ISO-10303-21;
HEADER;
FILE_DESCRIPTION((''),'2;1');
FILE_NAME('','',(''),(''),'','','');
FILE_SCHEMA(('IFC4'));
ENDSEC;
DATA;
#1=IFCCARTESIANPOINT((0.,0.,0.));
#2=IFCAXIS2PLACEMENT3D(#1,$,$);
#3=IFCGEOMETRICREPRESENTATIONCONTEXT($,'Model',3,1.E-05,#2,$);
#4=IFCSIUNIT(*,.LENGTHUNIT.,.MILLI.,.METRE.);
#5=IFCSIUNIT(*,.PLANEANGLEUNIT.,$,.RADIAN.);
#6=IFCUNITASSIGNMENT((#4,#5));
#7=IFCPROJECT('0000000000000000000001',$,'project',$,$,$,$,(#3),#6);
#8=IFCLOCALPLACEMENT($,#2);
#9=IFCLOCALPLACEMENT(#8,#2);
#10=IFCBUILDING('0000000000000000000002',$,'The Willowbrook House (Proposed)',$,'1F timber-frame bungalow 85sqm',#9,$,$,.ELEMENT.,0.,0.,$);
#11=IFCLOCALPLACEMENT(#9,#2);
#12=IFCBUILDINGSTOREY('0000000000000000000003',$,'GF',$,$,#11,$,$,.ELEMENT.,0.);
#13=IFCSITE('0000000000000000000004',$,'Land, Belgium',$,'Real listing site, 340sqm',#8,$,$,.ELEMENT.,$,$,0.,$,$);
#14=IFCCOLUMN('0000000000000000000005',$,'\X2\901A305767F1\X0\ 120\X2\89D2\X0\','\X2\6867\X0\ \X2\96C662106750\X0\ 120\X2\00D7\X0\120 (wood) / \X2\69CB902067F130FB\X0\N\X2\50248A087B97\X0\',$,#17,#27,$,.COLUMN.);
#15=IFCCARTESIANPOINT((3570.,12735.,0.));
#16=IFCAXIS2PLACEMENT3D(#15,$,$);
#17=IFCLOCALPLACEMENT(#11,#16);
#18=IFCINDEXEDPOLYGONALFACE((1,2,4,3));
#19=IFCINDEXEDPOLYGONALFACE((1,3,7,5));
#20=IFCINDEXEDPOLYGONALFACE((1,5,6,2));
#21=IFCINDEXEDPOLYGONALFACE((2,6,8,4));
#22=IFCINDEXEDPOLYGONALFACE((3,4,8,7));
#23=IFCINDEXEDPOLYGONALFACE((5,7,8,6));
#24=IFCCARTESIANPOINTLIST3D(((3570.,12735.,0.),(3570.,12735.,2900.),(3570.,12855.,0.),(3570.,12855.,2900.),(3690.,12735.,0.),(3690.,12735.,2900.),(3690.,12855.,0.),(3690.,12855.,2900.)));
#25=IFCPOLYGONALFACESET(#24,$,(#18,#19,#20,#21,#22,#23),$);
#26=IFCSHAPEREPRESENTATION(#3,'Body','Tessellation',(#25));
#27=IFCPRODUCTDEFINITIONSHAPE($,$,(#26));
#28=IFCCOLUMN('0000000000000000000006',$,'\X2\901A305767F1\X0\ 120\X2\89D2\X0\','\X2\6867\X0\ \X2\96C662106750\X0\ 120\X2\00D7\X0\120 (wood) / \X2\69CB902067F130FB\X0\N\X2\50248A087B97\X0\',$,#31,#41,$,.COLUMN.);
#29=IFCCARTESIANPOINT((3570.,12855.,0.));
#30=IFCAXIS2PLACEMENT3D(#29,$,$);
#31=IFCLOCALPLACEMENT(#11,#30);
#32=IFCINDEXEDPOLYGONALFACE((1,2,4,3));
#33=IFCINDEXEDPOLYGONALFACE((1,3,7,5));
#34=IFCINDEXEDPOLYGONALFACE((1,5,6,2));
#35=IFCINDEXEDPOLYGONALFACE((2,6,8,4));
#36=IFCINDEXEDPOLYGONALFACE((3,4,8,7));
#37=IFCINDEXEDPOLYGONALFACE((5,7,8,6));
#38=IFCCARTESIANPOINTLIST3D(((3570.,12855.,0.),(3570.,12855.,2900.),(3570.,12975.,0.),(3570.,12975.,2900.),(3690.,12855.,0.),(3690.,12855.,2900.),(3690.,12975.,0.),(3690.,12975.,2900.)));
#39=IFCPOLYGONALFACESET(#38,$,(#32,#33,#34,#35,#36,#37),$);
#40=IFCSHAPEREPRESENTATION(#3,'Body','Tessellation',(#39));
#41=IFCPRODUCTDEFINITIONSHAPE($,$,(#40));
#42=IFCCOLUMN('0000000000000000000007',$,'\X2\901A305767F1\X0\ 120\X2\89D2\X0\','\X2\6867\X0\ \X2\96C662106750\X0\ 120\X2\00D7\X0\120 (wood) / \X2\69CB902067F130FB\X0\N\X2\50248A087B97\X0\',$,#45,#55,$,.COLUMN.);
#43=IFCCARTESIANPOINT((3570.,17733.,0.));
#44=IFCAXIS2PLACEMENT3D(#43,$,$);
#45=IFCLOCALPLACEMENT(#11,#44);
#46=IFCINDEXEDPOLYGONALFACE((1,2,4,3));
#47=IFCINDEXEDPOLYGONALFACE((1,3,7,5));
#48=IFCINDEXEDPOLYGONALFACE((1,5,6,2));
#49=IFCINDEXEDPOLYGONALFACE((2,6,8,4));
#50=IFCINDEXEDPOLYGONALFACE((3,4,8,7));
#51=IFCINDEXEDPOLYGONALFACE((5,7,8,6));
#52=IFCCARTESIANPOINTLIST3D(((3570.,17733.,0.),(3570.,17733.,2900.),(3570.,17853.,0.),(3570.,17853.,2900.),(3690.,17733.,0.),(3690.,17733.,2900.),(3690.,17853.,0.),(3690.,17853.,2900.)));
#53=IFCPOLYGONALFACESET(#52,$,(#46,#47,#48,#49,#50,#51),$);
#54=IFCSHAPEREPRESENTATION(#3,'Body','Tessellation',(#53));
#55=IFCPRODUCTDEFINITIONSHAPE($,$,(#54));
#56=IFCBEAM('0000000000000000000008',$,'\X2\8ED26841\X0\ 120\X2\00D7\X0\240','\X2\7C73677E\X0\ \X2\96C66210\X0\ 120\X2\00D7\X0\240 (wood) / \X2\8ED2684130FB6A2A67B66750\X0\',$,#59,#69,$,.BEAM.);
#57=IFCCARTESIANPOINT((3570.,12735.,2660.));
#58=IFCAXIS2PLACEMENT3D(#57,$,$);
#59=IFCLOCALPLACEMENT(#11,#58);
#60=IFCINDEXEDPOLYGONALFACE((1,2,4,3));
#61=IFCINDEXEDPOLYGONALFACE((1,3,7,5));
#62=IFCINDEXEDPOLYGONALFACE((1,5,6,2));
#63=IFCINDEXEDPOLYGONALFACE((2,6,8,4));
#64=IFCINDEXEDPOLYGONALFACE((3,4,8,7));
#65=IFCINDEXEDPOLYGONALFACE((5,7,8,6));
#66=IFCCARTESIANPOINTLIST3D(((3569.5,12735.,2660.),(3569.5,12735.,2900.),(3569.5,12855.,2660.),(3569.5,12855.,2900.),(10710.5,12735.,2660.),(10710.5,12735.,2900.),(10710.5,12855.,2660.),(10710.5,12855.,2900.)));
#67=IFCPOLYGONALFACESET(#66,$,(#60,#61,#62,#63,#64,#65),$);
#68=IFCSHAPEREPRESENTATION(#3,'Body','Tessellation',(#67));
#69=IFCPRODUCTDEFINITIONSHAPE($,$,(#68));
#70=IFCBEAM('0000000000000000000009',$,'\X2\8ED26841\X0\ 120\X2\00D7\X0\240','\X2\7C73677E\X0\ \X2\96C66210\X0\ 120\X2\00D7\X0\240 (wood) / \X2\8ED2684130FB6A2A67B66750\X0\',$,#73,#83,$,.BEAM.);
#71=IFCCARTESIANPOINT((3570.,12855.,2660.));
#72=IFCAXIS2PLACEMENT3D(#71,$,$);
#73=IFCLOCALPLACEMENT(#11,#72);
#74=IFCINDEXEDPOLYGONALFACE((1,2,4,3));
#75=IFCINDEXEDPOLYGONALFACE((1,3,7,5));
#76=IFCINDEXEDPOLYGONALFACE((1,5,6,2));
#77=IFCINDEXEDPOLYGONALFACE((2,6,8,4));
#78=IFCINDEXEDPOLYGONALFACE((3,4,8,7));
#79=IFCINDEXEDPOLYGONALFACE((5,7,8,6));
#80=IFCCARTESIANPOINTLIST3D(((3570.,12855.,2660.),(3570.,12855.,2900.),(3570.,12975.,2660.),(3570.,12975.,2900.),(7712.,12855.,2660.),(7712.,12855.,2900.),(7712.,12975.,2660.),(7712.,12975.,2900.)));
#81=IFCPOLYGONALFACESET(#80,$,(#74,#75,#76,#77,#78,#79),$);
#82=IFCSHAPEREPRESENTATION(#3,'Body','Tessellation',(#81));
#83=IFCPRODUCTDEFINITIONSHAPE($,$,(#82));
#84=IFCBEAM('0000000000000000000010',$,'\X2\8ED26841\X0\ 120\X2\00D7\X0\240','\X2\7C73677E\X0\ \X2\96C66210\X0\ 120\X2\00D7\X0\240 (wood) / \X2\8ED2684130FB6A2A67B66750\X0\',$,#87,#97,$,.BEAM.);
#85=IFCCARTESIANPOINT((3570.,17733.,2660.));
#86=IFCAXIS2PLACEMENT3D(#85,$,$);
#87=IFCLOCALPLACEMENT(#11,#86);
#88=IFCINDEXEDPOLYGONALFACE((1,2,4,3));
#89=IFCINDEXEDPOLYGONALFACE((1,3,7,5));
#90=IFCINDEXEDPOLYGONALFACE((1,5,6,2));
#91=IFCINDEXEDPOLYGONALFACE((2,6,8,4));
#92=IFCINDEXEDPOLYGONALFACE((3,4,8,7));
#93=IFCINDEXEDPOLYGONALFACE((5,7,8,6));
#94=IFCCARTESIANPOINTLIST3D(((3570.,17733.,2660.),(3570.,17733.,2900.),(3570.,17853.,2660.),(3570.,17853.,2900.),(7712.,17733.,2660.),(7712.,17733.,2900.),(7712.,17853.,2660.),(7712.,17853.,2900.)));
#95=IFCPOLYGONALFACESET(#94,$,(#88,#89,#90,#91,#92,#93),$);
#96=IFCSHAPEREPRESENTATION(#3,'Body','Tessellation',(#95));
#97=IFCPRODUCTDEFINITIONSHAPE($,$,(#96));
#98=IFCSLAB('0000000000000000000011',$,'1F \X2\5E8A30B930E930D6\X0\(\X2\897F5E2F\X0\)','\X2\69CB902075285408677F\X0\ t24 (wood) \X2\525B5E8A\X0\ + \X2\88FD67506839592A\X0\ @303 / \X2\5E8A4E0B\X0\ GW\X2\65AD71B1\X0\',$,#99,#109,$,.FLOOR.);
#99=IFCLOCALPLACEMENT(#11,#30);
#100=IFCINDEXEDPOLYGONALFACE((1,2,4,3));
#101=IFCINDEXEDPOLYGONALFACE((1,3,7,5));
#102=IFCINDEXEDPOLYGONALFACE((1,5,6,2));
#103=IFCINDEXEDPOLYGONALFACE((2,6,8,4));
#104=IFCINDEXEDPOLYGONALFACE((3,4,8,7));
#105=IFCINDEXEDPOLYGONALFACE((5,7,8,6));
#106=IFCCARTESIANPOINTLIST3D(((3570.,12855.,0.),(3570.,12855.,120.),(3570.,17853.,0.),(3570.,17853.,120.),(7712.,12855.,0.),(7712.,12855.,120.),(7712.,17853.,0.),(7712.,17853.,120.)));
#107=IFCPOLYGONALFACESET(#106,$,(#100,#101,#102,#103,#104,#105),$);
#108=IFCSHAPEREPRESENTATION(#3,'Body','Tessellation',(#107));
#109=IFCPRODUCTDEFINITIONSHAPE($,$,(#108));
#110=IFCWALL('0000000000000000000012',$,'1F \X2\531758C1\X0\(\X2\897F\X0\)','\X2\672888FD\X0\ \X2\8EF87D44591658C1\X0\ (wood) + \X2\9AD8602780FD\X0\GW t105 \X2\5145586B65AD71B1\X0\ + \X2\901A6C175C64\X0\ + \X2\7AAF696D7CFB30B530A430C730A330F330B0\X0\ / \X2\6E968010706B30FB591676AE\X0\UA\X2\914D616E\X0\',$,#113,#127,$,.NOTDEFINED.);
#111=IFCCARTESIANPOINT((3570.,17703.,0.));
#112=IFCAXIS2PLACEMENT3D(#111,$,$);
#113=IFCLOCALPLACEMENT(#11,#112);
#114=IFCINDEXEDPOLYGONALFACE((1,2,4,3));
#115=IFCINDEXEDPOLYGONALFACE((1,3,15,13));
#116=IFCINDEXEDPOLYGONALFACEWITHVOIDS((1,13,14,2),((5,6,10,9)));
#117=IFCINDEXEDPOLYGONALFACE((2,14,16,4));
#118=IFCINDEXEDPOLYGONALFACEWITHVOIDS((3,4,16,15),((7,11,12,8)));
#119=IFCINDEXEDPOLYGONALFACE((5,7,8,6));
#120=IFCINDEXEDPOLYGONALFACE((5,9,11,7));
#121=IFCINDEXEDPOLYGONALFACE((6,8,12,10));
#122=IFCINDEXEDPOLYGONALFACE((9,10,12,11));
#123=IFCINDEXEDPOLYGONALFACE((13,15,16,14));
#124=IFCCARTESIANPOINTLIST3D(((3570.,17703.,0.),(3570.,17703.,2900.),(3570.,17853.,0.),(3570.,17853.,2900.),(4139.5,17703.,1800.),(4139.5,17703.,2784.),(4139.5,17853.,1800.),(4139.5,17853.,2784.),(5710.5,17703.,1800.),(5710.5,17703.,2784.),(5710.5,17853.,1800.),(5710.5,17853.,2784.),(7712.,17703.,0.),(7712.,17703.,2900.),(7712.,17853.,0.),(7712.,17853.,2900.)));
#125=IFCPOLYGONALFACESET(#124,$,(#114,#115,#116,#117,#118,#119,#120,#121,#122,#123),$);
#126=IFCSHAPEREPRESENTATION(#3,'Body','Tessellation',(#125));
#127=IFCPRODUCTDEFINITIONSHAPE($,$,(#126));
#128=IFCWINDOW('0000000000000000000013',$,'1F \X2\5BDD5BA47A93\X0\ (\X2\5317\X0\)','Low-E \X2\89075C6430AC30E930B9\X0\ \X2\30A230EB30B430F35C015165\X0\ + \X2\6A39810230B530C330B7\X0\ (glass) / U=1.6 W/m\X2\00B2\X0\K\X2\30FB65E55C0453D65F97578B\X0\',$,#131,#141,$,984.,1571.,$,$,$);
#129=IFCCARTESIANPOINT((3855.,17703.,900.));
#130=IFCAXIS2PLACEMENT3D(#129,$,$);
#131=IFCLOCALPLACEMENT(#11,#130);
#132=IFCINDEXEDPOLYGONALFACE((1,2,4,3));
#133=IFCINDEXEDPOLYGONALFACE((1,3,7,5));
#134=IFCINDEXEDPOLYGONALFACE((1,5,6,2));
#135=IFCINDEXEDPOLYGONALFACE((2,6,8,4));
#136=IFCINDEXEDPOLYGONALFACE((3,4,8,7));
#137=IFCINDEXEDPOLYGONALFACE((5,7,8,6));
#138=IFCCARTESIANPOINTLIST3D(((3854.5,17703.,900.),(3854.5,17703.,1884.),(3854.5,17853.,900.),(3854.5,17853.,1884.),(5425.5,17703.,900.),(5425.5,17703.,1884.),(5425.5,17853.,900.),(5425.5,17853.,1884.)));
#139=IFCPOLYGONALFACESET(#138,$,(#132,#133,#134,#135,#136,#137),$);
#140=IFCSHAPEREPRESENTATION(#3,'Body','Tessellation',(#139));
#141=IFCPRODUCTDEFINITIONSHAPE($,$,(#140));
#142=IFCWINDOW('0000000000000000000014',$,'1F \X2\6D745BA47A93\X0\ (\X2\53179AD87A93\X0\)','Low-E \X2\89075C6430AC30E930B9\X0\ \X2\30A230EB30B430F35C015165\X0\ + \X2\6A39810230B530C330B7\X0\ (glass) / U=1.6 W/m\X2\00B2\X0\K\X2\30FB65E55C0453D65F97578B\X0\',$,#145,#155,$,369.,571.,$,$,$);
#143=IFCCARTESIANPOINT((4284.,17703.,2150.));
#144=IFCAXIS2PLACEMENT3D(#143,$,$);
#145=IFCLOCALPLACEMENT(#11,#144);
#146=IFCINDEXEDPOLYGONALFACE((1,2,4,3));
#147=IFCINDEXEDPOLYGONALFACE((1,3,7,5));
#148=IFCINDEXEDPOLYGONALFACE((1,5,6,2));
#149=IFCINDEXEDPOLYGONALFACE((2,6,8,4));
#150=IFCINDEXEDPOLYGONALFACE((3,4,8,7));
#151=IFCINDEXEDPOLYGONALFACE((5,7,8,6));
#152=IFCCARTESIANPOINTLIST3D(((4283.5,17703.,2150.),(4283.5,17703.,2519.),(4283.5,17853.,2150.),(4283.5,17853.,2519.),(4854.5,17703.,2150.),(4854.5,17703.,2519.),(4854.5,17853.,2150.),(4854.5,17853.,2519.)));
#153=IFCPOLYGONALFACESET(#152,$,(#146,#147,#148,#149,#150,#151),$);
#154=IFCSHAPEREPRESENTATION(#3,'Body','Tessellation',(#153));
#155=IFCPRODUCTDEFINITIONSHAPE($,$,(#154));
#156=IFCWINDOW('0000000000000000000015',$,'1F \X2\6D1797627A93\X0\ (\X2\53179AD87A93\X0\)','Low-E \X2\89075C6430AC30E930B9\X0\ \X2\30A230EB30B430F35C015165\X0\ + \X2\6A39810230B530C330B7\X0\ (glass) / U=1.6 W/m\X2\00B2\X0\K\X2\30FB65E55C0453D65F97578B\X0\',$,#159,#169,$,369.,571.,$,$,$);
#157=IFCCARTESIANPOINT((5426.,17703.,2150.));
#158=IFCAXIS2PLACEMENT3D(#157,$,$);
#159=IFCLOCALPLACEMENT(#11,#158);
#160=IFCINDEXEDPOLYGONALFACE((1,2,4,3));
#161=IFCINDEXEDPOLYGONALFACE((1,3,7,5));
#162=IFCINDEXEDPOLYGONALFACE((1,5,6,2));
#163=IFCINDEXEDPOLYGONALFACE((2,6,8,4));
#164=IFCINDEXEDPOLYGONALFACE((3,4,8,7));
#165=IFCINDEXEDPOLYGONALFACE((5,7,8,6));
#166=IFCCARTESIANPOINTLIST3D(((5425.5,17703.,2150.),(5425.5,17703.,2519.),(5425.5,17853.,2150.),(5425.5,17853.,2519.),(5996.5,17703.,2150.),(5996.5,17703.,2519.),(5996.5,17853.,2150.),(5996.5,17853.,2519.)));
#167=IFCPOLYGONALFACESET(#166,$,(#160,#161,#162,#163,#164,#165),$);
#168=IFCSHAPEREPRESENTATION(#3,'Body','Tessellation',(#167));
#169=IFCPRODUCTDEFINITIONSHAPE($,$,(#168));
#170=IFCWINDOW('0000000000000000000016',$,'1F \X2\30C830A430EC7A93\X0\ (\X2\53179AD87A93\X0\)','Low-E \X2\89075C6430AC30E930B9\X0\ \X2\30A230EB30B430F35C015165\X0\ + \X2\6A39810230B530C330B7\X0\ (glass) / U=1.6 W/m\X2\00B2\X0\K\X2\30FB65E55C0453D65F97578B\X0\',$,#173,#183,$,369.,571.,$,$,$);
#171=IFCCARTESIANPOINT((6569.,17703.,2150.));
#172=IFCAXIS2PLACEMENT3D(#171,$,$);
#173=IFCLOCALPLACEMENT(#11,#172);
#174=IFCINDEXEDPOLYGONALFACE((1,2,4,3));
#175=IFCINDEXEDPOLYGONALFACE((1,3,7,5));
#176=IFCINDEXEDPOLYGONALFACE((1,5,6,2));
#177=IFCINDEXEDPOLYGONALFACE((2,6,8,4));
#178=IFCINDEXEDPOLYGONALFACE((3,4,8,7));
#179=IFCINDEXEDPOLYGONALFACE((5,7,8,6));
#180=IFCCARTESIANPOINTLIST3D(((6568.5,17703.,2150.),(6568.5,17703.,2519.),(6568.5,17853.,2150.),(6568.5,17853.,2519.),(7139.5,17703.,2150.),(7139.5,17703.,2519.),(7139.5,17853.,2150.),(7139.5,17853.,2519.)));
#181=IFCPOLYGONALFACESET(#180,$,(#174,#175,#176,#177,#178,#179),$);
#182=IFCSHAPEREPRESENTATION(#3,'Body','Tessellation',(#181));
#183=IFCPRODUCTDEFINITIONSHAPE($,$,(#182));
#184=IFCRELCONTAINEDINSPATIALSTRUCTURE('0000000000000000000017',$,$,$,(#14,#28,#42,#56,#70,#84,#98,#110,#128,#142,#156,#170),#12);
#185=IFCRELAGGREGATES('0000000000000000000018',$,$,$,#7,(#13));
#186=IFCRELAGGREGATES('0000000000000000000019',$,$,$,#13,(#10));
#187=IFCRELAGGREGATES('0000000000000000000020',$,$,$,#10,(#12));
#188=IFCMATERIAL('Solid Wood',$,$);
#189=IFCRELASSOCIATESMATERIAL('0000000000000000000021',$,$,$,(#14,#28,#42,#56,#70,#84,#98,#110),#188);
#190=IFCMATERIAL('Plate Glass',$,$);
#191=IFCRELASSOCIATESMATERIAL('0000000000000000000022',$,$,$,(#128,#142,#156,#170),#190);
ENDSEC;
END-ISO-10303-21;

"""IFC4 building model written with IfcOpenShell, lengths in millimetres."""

from ifc_helpers import new_model, si_unit, frame, frame_2d, origin, place, context, project, spatial, rectangle, extrude, material, element, fill, save


model = new_model("IFC4")

# Units and contexts
model_context = context("Model", 3, precision=1e-05, world=origin())
ifc_project = project(units=[si_unit("LENGTHUNIT", "METRE", prefix="MILLI"), si_unit("PLANEANGLEUNIT", "RADIAN")], contexts=[model_context])

# Site, building, storey
site_placement = place(None, origin())
site = spatial("IfcSite", under=ifc_project, at=site_placement, Name="Land, Belgium", ObjectType="Real listing site, 340sqm", CompositionType="ELEMENT", RefElevation=0.0)
building_placement = place(site_placement, origin())
building = spatial("IfcBuilding", under=site, at=building_placement, Name="The Willowbrook House (Proposed)", ObjectType="1F timber-frame bungalow 85sqm", CompositionType="ELEMENT", ElevationOfRefHeight=0.0, ElevationOfTerrain=0.0)
storey_placement = place(building_placement, origin())
storey = spatial("IfcBuildingStorey", under=building, at=storey_placement, Name="GF", CompositionType="ELEMENT", Elevation=0.0)

# Columns
ifc_material_1 = material(Name="Solid Wood")
column_1_placement = place(storey_placement, frame((3570.0, 12735.0, 0.0)))
element("IfcColumn", 1, at=column_1_placement, inside=storey, material=ifc_material_1, Name="通し柱 120角", Description="桧 集成材 120×120 (wood) / 構造柱・N値計算", PredefinedType="COLUMN", context=model_context, shape_type="SweptSolid", body=[
    extrude(rectangle(XDim=120.0, YDim=120.0, at=frame_2d((60.0, 60.0))), frame((3570.0, 12735.0, 0.0)), (0.0, 0.0, 1.0), 2900.0),
])
column_2_placement = place(storey_placement, frame((3570.0, 12855.0, 0.0)))
element("IfcColumn", 2, at=column_2_placement, inside=storey, material=ifc_material_1, Name="通し柱 120角", Description="桧 集成材 120×120 (wood) / 構造柱・N値計算", PredefinedType="COLUMN", context=model_context, shape_type="SweptSolid", body=[
    extrude(rectangle(XDim=120.0, YDim=120.0, at=frame_2d((60.0, 60.0))), frame((3570.0, 12855.0, 0.0)), (0.0, 0.0, 1.0), 2900.0),
])
column_3_placement = place(storey_placement, frame((3570.0, 17733.0, 0.0)))
element("IfcColumn", 3, at=column_3_placement, inside=storey, material=ifc_material_1, Name="通し柱 120角", Description="桧 集成材 120×120 (wood) / 構造柱・N値計算", PredefinedType="COLUMN", context=model_context, shape_type="SweptSolid", body=[
    extrude(rectangle(XDim=120.0, YDim=120.0, at=frame_2d((60.0, 60.0))), frame((3570.0, 17733.0, 0.0)), (0.0, 0.0, 1.0), 2900.0),
])

# Beams
beam_1_placement = place(storey_placement, frame((3570.0, 12735.0, 2660.0)))
element("IfcBeam", 4, at=beam_1_placement, inside=storey, material=ifc_material_1, Name="軒桁 120×240", Description="米松 集成 120×240 (wood) / 軒桁・横架材", PredefinedType="BEAM", context=model_context, shape_type="SweptSolid", body=[
    extrude(rectangle(XDim=7141.0, YDim=120.0, at=frame_2d((3570.0, 60.0))), frame((3570.0, 12735.0, 2660.0)), (0.0, 0.0, 1.0), 240.0),
])
beam_2_placement = place(storey_placement, frame((3570.0, 12855.0, 2660.0)))
element("IfcBeam", 5, at=beam_2_placement, inside=storey, material=ifc_material_1, Name="軒桁 120×240", Description="米松 集成 120×240 (wood) / 軒桁・横架材", PredefinedType="BEAM", context=model_context, shape_type="SweptSolid", body=[
    extrude(rectangle(XDim=4142.0, YDim=120.0, at=frame_2d((2071.0, 60.0))), frame((3570.0, 12855.0, 2660.0)), (0.0, 0.0, 1.0), 240.0),
])
beam_3_placement = place(storey_placement, frame((3570.0, 17733.0, 2660.0)))
element("IfcBeam", 6, at=beam_3_placement, inside=storey, material=ifc_material_1, Name="軒桁 120×240", Description="米松 集成 120×240 (wood) / 軒桁・横架材", PredefinedType="BEAM", context=model_context, shape_type="SweptSolid", body=[
    extrude(rectangle(XDim=4142.0, YDim=120.0, at=frame_2d((2071.0, 60.0))), frame((3570.0, 17733.0, 2660.0)), (0.0, 0.0, 1.0), 240.0),
])

# Slab
slab_placement = place(storey_placement, frame((3570.0, 12855.0, 0.0)))
element("IfcSlab", 7, at=slab_placement, inside=storey, material=ifc_material_1, Name="1F 床スラブ(西帯)", Description="構造用合板 t24 (wood) 剛床 + 製材根太 @303 / 床下 GW断熱", PredefinedType="FLOOR", context=model_context, shape_type="SweptSolid", body=[
    extrude(rectangle(XDim=4142.0, YDim=4998.0, at=frame_2d((2071.0, 2499.0))), frame((3570.0, 12855.0, 0.0)), (0.0, 0.0, 1.0), 120.0),
])

# Wall, openings, windows
wall_1_placement = place(storey_placement, frame((3570.0, 17703.0, 0.0)))
wall_1 = element("IfcWall", 8, at=wall_1_placement, inside=storey, material=ifc_material_1, Name="1F 北壁(西)", Description="木製 軸組外壁 (wood) + 高性能GW t105 充填断熱 + 通気層 + 窯業系サイディング / 準耐火・外皮UA配慮", PredefinedType="NOTDEFINED", context=model_context, shape_type="SweptSolid", body=[
    extrude(rectangle(XDim=4142.0, YDim=150.0, at=frame_2d((2071.0, 75.0))), frame((3570.0, 17703.0, 0.0)), (0.0, 0.0, 1.0), 2900.0),
])
opening_1_placement = place(storey_placement, frame((3855.0, 17703.0, 900.0)))
opening_1 = element("IfcOpeningElement", 9, at=opening_1_placement, cuts=wall_1, PredefinedType="NOTDEFINED", context=model_context, shape_type="SweptSolid", body=[
    extrude(rectangle(XDim=1571.0, YDim=150.0, at=frame_2d((785.0, 75.0))), frame((3855.0, 17703.0, 900.0)), (0.0, 0.0, 1.0), 984.0),
])
opening_2_placement = place(storey_placement, frame((4284.0, 17703.0, 2150.0)))
opening_2 = element("IfcOpeningElement", 10, at=opening_2_placement, cuts=wall_1, PredefinedType="NOTDEFINED", context=model_context, shape_type="SweptSolid", body=[
    extrude(rectangle(XDim=571.0, YDim=150.0, at=frame_2d((285.0, 75.0))), frame((4284.0, 17703.0, 2150.0)), (0.0, 0.0, 1.0), 369.0),
])
opening_3_placement = place(storey_placement, frame((5426.0, 17703.0, 2150.0)))
opening_3 = element("IfcOpeningElement", 11, at=opening_3_placement, cuts=wall_1, PredefinedType="NOTDEFINED", context=model_context, shape_type="SweptSolid", body=[
    extrude(rectangle(XDim=571.0, YDim=150.0, at=frame_2d((285.0, 75.0))), frame((5426.0, 17703.0, 2150.0)), (0.0, 0.0, 1.0), 369.0),
])
opening_4_placement = place(storey_placement, frame((6569.0, 17703.0, 2150.0)))
opening_4 = element("IfcOpeningElement", 12, at=opening_4_placement, cuts=wall_1, PredefinedType="NOTDEFINED", context=model_context, shape_type="SweptSolid", body=[
    extrude(rectangle(XDim=571.0, YDim=150.0, at=frame_2d((285.0, 75.0))), frame((6569.0, 17703.0, 2150.0)), (0.0, 0.0, 1.0), 369.0),
])
ifc_material_2 = material(Name="Plate Glass")
window_1_placement = place(storey_placement, frame((3855.0, 17703.0, 900.0)))
window_1 = element("IfcWindow", 13, at=window_1_placement, inside=storey, material=ifc_material_2, Name="1F 寝室窓 (北)", Description="Low-E 複層ガラス アルゴン封入 + 樹脂サッシ (glass) / U=1.6 W/m²K・日射取得型", OverallHeight=984.0, OverallWidth=1571.0, context=model_context, shape_type="SweptSolid", body=[
    extrude(rectangle(XDim=1571.0, YDim=150.0, at=frame_2d((785.0, 75.0))), frame((3855.0, 17703.0, 900.0)), (0.0, 0.0, 1.0), 984.0),
])
fill(opening_1, window_1)
window_2_placement = place(storey_placement, frame((4284.0, 17703.0, 2150.0)))
window_2 = element("IfcWindow", 14, at=window_2_placement, inside=storey, material=ifc_material_2, Name="1F 浴室窓 (北高窓)", Description="Low-E 複層ガラス アルゴン封入 + 樹脂サッシ (glass) / U=1.6 W/m²K・日射取得型", OverallHeight=369.0, OverallWidth=571.0, context=model_context, shape_type="SweptSolid", body=[
    extrude(rectangle(XDim=571.0, YDim=150.0, at=frame_2d((285.0, 75.0))), frame((4284.0, 17703.0, 2150.0)), (0.0, 0.0, 1.0), 369.0),
])
fill(opening_2, window_2)
window_3_placement = place(storey_placement, frame((5426.0, 17703.0, 2150.0)))
window_3 = element("IfcWindow", 15, at=window_3_placement, inside=storey, material=ifc_material_2, Name="1F 洗面窓 (北高窓)", Description="Low-E 複層ガラス アルゴン封入 + 樹脂サッシ (glass) / U=1.6 W/m²K・日射取得型", OverallHeight=369.0, OverallWidth=571.0, context=model_context, shape_type="SweptSolid", body=[
    extrude(rectangle(XDim=571.0, YDim=150.0, at=frame_2d((285.0, 75.0))), frame((5426.0, 17703.0, 2150.0)), (0.0, 0.0, 1.0), 369.0),
])
fill(opening_3, window_3)
window_4_placement = place(storey_placement, frame((6569.0, 17703.0, 2150.0)))
window_4 = element("IfcWindow", 16, at=window_4_placement, inside=storey, material=ifc_material_2, Name="1F トイレ窓 (北高窓)", Description="Low-E 複層ガラス アルゴン封入 + 樹脂サッシ (glass) / U=1.6 W/m²K・日射取得型", OverallHeight=369.0, OverallWidth=571.0, context=model_context, shape_type="SweptSolid", body=[
    extrude(rectangle(XDim=571.0, YDim=150.0, at=frame_2d((285.0, 75.0))), frame((6569.0, 17703.0, 2150.0)), (0.0, 0.0, 1.0), 369.0),
])
fill(opening_4, window_4)

save(model, "model.ifc")
